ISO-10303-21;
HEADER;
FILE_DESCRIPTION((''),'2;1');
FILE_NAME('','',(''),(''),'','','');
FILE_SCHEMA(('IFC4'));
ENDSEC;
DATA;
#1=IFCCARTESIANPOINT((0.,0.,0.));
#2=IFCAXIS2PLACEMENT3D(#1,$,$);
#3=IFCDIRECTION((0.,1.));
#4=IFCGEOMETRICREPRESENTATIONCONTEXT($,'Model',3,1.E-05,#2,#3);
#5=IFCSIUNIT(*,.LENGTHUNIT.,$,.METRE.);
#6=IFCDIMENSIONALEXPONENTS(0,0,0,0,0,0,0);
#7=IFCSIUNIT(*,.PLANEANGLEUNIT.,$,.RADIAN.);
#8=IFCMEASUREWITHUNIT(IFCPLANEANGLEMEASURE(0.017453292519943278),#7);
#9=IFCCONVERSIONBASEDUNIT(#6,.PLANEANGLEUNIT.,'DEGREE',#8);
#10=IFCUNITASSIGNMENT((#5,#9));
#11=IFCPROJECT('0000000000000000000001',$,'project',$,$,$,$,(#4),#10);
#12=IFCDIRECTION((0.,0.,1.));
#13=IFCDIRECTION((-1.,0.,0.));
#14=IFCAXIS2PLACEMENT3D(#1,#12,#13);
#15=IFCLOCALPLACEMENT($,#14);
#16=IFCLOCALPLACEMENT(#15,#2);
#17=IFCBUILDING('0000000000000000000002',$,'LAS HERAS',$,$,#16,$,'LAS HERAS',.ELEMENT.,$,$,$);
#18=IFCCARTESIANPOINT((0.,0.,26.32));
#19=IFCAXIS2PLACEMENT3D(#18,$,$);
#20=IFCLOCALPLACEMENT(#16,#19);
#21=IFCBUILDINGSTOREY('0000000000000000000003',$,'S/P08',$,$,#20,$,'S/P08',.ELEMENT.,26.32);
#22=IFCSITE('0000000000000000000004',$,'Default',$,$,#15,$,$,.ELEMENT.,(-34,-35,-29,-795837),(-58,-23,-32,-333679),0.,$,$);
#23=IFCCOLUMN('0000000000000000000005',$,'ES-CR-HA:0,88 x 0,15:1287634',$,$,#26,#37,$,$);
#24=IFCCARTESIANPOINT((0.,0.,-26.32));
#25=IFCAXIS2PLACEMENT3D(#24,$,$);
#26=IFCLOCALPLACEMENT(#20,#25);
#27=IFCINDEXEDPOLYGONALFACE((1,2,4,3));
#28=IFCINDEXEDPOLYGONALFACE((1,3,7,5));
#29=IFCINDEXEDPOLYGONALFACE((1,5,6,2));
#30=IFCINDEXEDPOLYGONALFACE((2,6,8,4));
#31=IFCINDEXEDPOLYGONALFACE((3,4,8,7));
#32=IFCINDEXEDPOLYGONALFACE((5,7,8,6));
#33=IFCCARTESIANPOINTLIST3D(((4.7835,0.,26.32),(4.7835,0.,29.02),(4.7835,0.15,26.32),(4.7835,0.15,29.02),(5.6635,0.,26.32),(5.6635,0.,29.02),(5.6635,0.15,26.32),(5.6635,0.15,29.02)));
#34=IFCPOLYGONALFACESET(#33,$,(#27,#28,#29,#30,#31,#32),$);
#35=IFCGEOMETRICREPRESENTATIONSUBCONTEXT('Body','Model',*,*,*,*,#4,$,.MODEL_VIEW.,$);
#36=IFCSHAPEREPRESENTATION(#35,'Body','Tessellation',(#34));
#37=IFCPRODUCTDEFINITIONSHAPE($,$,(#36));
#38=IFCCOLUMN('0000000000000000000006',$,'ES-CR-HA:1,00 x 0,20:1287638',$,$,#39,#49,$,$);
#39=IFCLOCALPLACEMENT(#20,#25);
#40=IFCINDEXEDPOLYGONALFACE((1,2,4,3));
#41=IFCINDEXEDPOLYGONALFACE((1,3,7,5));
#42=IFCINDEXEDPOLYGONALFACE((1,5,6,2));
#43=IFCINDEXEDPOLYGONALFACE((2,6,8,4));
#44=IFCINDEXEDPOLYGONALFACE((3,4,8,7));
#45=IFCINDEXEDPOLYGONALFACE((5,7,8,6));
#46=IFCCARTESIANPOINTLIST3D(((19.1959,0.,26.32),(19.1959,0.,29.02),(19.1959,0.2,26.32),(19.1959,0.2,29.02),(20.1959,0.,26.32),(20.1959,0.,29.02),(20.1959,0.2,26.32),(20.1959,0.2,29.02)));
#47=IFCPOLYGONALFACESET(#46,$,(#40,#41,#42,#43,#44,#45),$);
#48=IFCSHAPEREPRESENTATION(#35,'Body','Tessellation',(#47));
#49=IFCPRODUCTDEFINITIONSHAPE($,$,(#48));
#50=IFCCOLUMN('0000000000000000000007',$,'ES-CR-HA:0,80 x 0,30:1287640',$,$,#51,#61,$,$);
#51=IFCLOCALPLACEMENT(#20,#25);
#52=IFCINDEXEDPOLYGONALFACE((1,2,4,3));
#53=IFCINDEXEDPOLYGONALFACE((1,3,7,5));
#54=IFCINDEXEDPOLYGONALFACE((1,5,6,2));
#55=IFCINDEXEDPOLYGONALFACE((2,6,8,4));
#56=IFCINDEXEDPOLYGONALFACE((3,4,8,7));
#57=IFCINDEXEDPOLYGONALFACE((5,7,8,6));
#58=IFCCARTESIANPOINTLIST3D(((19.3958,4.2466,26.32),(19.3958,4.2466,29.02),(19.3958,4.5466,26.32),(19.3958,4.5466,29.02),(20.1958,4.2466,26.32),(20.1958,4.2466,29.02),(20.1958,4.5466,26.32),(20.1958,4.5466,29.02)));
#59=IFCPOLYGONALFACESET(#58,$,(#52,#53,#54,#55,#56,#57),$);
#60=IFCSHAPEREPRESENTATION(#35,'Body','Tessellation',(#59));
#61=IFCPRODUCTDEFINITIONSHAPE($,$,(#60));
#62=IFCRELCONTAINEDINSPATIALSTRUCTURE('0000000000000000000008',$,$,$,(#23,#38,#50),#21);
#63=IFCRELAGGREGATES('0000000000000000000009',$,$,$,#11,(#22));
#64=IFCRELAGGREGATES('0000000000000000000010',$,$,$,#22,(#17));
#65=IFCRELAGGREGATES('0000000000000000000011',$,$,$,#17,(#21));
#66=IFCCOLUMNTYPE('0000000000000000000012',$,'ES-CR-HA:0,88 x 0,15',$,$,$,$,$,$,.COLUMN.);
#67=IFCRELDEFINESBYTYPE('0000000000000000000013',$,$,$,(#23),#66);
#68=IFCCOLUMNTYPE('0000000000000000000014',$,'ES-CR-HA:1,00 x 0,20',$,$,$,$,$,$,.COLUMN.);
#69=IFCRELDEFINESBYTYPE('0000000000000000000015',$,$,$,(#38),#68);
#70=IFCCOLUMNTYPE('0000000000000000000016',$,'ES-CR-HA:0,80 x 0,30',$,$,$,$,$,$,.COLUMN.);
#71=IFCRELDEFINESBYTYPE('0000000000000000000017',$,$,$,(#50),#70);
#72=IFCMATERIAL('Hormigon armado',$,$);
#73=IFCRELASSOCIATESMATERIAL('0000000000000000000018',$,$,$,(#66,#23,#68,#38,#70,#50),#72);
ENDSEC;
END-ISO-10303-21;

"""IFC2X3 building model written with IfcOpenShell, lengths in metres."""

from ifc_helpers import new_model, entity, si_unit, converted_unit, direction, frame, frame_2d, origin, origin_2d_with_axis, place, context, subcontext, project, spatial, rectangle, extrude, source, transform, mapped, material, type_object, type_shapes, element, save


model = new_model("IFC2X3")

# Units and contexts
model_context = context("Model", 3, precision=1e-05, world=origin(), true_north=direction((0.0, 1.0)))
body_context = subcontext(model_context, "Body", "Model", "MODEL_VIEW")
ifc_project = project(units=[si_unit("LENGTHUNIT", "METRE"), converted_unit("PLANEANGLEUNIT", "DEGREE", entity("IfcPlaneAngleMeasure", 0.017453292519943278), si_unit("PLANEANGLEUNIT", "RADIAN"), dimensions=[0, 0, 0, 0, 0, 0, 0])], contexts=[model_context])

# Site, building, storey
site_placement = place(None, frame((0.0, 0.0, 0.0), z_axis=(0.0, 0.0, 1.0), x_axis=(-1.0, 0.0, 0.0)))
site = spatial("IfcSite", under=ifc_project, at=site_placement, Name="Default", CompositionType="ELEMENT", RefLatitude=(-34, -35, -29, -795837), RefLongitude=(-58, -23, -32, -333679), RefElevation=0.0)
building_placement = place(site_placement, origin())
building = spatial("IfcBuilding", under=site, at=building_placement, Name="LAS HERAS", LongName="LAS HERAS", CompositionType="ELEMENT")
storey_placement = place(building_placement, frame((0.0, 0.0, 26.32)))
storey = spatial("IfcBuildingStorey", under=building, at=storey_placement, Name="S/P08", LongName="S/P08", CompositionType="ELEMENT", Elevation=26.32)

# Columns
ifc_material = material(Name="Hormigon armado")
column_type_1 = type_object("IfcColumnType", Name="ES-CR-HA:0,88 x 0,15", PredefinedType="COLUMN", material=ifc_material)
shared_shape_1 = source(origin(), body_context, "Body", "SweptSolid", [
    extrude(rectangle(XDim=2.7, YDim=0.15, at=frame_2d((0.0, 0.0), x_axis=(1.0, 0.0))), frame((4.7835, 0.075, 27.67), z_axis=(1.0, 0.0, 0.0), x_axis=(0.0, 0.0, 1.0)), (0.0, 0.0, 1.0), 0.88),
])
type_shapes(column_type_1, [shared_shape_1])
column_1_placement = place(storey_placement, frame((0.0, 0.0, -26.32)))
element("IfcColumn", 1, at=column_1_placement, inside=storey, type_object=column_type_1, material=ifc_material, Name="ES-CR-HA:0,88 x 0,15:1287634", context=body_context, shape_type="MappedRepresentation", body=[
    mapped(shared_shape_1, transform((0.0, 0.0, 0.0), scale=1.0)),
])
column_type_2 = type_object("IfcColumnType", Name="ES-CR-HA:1,00 x 0,20", PredefinedType="COLUMN", material=ifc_material)
shared_shape_2 = source(origin(), body_context, "Body", "SweptSolid", [
    extrude(rectangle(XDim=2.7, YDim=0.2, at=frame_2d((0.0, 0.0), x_axis=(1.0, 0.0))), frame((19.1959, 0.1, 27.67), z_axis=(1.0, 0.0, 0.0), x_axis=(0.0, 0.0, 1.0)), (0.0, 0.0, 1.0), 1.0),
])
type_shapes(column_type_2, [shared_shape_2])
column_2_placement = place(storey_placement, frame((0.0, 0.0, -26.32)))
element("IfcColumn", 2, at=column_2_placement, inside=storey, type_object=column_type_2, material=ifc_material, Name="ES-CR-HA:1,00 x 0,20:1287638", context=body_context, shape_type="MappedRepresentation", body=[
    mapped(shared_shape_2, transform((0.0, 0.0, 0.0), scale=1.0)),
])
column_type_3 = type_object("IfcColumnType", Name="ES-CR-HA:0,80 x 0,30", PredefinedType="COLUMN", material=ifc_material)
shared_shape_3 = source(origin(), body_context, "Body", "SweptSolid", [
    extrude(rectangle(XDim=2.7, YDim=0.3, at=origin_2d_with_axis()), frame((19.3958, 4.3966, 27.67), z_axis=(1.0, 0.0, 0.0), x_axis=(0.0, 0.0, 1.0)), (0.0, 0.0, 1.0), 0.8),
])
type_shapes(column_type_3, [shared_shape_3])
column_3_placement = place(storey_placement, frame((0.0, 0.0, -26.32)))
element("IfcColumn", 3, at=column_3_placement, inside=storey, type_object=column_type_3, material=ifc_material, Name="ES-CR-HA:0,80 x 0,30:1287640", context=body_context, shape_type="MappedRepresentation", body=[
    mapped(shared_shape_3, transform((0.0, 0.0, 0.0), scale=1.0)),
])

save(model, "model.ifc")
